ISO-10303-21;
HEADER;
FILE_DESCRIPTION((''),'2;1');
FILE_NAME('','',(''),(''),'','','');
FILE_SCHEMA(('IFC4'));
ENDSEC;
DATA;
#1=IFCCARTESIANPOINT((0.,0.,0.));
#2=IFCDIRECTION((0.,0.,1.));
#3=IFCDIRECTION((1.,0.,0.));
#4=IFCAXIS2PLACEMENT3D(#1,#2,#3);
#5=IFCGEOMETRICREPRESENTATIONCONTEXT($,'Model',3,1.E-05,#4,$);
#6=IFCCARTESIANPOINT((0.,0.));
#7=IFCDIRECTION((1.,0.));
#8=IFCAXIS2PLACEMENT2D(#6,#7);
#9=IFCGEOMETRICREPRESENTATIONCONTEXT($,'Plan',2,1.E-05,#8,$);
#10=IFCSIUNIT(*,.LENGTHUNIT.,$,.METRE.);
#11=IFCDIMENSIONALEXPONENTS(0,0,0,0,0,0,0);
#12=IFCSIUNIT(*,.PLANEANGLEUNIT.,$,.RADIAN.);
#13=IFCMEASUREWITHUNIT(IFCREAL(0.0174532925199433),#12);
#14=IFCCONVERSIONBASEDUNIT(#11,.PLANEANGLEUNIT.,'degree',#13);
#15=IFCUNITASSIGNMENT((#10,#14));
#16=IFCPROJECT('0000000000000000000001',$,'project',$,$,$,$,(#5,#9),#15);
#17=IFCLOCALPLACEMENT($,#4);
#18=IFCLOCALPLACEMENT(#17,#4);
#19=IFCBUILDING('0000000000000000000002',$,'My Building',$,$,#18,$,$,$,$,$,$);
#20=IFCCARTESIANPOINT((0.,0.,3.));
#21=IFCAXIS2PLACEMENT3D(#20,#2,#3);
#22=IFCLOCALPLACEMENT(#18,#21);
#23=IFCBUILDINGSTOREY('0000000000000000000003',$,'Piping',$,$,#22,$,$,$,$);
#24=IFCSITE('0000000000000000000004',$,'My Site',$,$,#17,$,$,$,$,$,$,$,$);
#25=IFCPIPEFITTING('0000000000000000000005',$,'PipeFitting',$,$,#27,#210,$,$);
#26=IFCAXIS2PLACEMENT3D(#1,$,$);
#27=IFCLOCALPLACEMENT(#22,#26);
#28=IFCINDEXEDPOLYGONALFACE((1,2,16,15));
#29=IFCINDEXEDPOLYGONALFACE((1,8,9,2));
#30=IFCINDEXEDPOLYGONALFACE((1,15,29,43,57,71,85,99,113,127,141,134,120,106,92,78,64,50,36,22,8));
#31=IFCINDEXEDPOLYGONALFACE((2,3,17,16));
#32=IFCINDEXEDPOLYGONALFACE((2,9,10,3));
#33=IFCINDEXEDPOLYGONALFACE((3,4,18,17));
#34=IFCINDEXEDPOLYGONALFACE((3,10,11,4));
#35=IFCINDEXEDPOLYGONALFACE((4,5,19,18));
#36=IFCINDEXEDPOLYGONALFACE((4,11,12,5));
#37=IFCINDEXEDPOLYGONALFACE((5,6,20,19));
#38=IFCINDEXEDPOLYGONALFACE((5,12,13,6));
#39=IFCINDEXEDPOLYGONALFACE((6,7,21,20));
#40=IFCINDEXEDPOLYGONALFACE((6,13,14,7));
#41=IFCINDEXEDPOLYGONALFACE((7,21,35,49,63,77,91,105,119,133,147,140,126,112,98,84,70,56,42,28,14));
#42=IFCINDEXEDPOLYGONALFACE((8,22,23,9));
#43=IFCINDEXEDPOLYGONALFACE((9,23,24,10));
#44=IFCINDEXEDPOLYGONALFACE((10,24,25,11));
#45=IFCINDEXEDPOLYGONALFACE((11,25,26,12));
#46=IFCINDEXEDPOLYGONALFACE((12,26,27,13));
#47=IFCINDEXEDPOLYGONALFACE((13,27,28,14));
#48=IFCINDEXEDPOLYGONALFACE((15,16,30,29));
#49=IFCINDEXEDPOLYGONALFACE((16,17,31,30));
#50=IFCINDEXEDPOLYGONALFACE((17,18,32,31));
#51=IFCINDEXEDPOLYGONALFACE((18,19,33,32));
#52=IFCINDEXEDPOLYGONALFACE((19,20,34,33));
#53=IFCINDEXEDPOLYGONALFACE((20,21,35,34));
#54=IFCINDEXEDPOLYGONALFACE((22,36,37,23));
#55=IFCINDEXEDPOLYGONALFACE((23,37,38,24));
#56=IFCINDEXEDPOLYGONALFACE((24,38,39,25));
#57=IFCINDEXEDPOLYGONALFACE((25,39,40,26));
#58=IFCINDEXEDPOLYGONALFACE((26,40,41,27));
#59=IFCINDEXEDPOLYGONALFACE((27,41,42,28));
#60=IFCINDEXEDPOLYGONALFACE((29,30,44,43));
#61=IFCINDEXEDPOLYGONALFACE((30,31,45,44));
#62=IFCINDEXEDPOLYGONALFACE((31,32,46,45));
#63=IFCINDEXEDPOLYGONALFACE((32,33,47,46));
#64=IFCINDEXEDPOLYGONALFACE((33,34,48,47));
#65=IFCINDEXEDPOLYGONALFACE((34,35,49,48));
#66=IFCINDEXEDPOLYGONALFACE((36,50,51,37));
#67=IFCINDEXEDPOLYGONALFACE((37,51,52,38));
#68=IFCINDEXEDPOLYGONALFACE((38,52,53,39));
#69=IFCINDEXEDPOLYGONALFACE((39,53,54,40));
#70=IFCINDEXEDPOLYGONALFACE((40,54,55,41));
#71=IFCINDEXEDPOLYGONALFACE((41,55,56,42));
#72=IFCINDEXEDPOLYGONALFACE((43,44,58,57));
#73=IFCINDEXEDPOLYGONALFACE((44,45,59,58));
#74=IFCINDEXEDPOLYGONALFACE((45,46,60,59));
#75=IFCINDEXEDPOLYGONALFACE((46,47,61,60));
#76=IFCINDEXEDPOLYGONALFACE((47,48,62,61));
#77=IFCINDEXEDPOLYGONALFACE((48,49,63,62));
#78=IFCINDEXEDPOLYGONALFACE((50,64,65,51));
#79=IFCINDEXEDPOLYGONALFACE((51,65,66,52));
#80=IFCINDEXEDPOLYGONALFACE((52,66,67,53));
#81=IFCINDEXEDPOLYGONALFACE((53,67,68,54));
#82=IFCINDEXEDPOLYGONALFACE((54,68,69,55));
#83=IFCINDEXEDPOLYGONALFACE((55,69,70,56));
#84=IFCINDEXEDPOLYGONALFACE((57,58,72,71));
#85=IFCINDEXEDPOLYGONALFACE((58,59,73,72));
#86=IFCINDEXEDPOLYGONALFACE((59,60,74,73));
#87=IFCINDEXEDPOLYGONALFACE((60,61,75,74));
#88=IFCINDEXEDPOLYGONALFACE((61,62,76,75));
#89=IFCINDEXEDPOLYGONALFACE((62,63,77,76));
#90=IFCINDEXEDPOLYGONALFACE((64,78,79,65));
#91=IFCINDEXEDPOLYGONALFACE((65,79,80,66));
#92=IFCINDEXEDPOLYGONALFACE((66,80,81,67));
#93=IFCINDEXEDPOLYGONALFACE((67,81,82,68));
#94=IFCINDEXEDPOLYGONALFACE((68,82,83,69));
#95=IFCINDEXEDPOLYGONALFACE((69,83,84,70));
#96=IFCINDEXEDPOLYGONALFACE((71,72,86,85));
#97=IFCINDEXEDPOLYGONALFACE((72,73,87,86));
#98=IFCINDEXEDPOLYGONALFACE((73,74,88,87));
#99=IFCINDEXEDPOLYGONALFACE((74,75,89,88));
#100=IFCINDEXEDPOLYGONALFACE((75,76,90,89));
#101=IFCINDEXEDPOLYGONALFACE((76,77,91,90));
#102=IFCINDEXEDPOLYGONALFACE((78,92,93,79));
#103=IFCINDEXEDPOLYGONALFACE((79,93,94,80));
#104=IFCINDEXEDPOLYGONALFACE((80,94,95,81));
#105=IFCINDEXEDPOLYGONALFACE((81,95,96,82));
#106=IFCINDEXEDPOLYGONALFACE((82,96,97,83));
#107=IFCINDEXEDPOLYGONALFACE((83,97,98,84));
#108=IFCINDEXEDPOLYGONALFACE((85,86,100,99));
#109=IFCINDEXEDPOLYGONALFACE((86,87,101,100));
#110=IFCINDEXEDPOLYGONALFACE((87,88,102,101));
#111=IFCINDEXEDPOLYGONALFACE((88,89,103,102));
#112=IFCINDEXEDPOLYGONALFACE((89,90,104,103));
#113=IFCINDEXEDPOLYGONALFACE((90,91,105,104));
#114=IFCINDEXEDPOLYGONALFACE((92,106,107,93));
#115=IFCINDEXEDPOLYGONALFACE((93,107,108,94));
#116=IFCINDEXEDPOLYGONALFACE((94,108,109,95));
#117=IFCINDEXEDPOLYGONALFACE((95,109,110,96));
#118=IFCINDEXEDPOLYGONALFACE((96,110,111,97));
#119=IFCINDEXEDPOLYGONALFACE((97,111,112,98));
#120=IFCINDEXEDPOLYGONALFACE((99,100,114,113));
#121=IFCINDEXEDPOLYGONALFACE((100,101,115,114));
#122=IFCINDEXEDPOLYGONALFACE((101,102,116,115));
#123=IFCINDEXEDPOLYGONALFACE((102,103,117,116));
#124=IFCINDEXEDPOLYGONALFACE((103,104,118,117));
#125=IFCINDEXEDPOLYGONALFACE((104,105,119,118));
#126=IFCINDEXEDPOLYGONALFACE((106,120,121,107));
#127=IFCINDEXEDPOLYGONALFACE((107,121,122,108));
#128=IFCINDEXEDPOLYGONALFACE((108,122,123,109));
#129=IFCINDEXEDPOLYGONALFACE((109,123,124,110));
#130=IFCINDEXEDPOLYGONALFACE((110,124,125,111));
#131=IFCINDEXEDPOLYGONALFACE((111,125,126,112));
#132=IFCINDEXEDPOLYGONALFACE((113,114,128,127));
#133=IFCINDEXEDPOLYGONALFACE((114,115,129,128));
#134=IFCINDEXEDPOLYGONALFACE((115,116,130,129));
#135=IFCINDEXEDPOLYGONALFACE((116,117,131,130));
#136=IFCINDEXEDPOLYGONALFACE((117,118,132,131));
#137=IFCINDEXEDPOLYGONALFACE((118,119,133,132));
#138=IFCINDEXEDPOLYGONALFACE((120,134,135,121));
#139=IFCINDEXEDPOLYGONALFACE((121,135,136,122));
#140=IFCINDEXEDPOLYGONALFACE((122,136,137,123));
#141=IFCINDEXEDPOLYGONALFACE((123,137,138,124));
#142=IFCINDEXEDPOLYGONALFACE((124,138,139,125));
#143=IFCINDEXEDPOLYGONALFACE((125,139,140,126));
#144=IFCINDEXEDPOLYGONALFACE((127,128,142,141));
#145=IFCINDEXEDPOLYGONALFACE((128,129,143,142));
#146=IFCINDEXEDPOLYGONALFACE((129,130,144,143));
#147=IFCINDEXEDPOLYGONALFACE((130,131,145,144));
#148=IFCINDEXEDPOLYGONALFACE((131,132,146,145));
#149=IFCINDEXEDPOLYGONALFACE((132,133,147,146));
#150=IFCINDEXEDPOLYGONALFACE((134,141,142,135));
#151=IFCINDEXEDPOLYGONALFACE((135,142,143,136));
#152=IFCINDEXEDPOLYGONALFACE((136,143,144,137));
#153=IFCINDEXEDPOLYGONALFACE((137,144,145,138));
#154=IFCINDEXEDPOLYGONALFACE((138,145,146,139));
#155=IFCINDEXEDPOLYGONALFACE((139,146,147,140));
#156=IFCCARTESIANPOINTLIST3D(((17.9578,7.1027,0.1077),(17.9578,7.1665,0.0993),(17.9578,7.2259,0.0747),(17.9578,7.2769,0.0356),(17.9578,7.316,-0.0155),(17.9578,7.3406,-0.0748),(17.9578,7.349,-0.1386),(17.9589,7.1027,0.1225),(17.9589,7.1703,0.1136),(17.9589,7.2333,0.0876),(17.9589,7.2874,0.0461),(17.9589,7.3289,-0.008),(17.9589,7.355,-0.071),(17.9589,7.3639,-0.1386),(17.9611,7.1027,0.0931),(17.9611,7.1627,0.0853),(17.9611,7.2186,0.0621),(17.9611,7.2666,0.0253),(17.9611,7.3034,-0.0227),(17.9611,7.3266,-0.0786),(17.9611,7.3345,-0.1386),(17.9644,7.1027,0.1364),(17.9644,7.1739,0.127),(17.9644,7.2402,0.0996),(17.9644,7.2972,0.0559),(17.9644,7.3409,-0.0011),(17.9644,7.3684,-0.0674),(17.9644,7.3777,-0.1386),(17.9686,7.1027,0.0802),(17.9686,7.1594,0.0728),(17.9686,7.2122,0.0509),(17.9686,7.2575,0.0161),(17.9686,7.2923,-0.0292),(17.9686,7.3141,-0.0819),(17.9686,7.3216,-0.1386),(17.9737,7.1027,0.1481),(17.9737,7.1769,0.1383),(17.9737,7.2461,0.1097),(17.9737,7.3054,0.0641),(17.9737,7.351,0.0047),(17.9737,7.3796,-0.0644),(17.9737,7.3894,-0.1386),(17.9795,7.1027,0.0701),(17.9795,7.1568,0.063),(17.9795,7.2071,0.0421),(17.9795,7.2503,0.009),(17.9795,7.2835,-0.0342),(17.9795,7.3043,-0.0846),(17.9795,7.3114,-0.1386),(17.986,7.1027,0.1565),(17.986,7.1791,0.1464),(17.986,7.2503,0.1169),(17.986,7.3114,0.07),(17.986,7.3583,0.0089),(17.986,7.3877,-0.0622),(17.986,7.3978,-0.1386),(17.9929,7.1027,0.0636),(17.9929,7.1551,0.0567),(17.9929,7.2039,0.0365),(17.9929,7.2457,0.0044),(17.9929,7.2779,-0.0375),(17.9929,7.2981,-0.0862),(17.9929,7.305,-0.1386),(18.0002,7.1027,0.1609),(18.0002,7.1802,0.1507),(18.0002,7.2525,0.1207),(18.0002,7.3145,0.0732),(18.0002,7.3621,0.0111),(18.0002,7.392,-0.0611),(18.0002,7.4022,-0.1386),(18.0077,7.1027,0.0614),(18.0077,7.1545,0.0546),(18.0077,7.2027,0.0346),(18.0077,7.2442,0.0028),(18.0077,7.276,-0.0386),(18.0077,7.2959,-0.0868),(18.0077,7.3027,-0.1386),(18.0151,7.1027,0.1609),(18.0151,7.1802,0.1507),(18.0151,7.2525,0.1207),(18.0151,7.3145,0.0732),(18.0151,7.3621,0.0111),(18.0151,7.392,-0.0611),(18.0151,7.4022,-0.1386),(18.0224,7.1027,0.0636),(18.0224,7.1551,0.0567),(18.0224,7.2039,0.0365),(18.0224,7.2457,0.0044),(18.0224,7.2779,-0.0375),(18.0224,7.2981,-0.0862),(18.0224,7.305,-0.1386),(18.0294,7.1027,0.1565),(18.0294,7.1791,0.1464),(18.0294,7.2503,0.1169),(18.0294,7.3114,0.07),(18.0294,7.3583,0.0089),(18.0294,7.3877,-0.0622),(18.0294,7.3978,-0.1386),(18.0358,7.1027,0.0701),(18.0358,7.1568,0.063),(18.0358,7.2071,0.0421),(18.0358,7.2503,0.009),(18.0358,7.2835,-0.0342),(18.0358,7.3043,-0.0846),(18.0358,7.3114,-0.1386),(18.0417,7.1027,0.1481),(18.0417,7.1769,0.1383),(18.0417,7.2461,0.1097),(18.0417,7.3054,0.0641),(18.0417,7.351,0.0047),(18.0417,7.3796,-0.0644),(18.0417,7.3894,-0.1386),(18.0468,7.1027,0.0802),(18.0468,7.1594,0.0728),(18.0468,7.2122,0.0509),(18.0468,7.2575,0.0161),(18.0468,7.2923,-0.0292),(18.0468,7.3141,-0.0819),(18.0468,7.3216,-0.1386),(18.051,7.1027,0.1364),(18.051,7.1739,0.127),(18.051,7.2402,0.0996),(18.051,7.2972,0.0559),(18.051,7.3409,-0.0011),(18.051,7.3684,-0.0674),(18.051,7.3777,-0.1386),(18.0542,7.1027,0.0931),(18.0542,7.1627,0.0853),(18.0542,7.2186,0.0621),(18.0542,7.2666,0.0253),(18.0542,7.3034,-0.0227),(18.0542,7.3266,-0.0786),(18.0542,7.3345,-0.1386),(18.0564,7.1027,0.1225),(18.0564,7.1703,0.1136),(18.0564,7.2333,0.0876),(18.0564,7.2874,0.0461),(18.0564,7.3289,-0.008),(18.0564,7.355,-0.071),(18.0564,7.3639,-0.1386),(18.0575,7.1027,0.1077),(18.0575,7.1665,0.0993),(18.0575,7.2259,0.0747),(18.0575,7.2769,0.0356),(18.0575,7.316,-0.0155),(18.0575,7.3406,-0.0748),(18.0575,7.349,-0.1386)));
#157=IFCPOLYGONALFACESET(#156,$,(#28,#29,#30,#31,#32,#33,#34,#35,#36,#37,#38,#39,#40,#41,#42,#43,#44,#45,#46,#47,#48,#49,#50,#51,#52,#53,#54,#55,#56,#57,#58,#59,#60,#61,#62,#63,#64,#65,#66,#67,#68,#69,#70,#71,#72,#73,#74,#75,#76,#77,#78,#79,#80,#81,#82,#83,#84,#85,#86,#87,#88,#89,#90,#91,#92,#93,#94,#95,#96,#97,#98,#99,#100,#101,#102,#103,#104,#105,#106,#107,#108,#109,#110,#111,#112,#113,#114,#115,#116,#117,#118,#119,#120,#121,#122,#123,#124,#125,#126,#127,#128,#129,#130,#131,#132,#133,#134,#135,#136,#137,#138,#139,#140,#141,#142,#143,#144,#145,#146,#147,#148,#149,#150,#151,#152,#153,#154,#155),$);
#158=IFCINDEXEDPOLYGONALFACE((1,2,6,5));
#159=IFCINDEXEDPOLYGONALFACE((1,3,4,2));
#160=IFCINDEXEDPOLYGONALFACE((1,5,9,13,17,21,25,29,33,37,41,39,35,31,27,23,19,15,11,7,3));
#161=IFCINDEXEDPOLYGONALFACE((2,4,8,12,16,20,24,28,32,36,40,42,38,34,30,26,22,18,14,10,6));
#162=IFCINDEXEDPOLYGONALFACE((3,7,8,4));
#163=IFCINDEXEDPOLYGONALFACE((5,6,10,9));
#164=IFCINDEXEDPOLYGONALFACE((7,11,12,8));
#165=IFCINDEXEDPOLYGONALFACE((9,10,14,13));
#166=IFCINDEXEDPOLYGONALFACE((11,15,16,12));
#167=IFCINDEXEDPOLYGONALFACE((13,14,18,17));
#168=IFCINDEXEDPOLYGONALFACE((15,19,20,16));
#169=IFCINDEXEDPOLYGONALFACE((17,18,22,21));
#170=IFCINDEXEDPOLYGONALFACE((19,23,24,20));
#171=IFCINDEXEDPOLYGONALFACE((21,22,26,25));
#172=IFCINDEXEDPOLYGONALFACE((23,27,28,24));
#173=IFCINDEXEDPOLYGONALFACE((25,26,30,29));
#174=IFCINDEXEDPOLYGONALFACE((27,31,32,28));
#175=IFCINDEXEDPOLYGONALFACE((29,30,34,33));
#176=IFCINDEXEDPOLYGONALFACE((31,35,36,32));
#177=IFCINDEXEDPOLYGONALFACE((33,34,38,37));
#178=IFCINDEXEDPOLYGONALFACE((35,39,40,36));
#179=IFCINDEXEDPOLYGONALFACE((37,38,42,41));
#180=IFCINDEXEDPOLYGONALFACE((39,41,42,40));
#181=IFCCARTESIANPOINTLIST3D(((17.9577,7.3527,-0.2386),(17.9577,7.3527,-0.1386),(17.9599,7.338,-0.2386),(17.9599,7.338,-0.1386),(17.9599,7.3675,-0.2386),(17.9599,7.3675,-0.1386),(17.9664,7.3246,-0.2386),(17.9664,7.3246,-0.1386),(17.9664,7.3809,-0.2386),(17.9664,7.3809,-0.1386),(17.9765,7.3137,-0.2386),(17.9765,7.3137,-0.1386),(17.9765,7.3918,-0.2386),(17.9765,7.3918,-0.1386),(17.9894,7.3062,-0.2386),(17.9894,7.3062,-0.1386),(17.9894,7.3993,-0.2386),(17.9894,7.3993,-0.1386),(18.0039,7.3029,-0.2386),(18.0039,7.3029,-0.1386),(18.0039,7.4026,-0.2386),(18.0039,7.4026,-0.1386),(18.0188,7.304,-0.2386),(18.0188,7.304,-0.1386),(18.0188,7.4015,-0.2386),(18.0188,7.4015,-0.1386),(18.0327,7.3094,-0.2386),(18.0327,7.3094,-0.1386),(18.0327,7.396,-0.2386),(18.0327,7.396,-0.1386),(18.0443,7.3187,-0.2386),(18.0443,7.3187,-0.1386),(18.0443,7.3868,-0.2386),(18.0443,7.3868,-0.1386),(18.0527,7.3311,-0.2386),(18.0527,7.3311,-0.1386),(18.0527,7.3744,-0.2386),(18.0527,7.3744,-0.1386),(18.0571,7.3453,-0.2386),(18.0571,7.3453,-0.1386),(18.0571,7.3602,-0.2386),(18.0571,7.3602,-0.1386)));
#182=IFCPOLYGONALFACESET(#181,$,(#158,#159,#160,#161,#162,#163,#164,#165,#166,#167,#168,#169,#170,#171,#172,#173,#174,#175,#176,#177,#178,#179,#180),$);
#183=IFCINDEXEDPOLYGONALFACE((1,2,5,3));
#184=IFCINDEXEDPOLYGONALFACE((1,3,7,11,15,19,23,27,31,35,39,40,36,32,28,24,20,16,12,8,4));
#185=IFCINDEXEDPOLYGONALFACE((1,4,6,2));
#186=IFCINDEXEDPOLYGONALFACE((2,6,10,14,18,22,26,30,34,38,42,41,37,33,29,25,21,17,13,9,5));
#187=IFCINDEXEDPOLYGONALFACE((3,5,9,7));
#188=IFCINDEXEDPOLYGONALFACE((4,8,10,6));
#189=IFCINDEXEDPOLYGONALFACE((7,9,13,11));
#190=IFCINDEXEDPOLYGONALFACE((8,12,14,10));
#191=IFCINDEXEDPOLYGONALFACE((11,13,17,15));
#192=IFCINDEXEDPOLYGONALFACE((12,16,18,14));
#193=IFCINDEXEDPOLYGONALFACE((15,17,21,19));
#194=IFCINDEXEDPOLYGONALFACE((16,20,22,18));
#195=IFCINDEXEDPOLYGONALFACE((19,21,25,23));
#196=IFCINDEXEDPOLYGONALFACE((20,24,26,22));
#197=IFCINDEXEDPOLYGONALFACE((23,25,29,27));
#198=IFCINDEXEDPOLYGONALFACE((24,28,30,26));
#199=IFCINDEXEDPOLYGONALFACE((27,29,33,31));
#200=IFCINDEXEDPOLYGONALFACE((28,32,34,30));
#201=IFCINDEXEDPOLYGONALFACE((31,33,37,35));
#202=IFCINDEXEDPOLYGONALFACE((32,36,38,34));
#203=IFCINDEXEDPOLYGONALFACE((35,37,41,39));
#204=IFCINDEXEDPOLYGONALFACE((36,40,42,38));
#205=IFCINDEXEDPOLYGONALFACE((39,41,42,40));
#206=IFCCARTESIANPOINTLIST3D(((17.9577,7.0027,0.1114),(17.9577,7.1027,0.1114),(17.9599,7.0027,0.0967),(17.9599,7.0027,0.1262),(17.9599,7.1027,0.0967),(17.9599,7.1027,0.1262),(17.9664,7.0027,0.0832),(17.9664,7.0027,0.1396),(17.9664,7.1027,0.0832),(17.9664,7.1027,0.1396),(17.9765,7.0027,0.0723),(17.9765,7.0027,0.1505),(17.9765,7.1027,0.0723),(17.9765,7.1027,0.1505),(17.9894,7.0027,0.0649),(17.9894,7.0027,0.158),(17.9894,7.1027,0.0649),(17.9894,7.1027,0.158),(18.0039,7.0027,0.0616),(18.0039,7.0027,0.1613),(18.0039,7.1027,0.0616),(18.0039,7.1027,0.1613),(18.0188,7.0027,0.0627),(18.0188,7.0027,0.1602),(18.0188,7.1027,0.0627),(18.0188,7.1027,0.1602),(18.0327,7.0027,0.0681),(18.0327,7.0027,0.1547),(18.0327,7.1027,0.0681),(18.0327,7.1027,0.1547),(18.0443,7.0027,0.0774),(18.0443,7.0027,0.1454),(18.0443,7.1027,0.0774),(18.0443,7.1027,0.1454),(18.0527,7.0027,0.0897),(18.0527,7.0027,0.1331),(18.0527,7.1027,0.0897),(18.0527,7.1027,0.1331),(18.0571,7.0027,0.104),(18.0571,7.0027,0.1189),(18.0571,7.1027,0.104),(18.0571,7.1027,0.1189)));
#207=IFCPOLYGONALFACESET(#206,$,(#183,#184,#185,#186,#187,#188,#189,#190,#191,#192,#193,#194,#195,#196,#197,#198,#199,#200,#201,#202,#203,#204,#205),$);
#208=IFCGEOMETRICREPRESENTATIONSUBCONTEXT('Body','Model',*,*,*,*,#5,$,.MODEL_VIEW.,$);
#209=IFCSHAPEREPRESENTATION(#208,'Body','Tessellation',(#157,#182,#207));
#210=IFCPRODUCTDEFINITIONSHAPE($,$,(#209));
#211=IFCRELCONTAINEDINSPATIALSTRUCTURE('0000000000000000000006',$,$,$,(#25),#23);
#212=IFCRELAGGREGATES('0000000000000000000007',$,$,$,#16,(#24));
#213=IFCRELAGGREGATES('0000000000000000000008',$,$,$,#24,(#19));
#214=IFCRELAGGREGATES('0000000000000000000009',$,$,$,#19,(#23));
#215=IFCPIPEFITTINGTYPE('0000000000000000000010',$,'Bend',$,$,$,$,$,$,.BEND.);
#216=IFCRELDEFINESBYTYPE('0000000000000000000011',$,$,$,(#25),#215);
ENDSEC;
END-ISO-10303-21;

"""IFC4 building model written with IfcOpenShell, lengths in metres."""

from ifc_helpers import new_model, entity, si_unit, converted_unit, frame, origin_with_axes, origin_2d_with_axis, place, context, subcontext, project, spatial, circle, extrude, source, transform, mapped, type_object, type_shapes, element, save


model = new_model("IFC4")

# Units and contexts
model_context = context("Model", 3, precision=1e-05, world=origin_with_axes())
plan_context = context("Plan", 2, precision=1e-05, world=origin_2d_with_axis())
body_context = subcontext(model_context, "Body", "Model", "MODEL_VIEW")
ifc_project = project(units=[si_unit("LENGTHUNIT", "METRE"), converted_unit("PLANEANGLEUNIT", "degree", entity("IfcReal", 0.0174532925199433), si_unit("PLANEANGLEUNIT", "RADIAN"), dimensions=[0, 0, 0, 0, 0, 0, 0])], contexts=[model_context, plan_context])

# Site, building, storey
site_placement = place(None, origin_with_axes())
site = spatial("IfcSite", under=ifc_project, at=site_placement, Name="My Site")
building_placement = place(site_placement, origin_with_axes())
building = spatial("IfcBuilding", under=site, at=building_placement, Name="My Building")
storey_placement = place(building_placement, frame((0.0, 0.0, 3.0), z_axis=(0.0, 0.0, 1.0), x_axis=(1.0, 0.0, 0.0)))
storey = spatial("IfcBuildingStorey", under=building, at=storey_placement, Name="Piping")

# Pipe fitting
pipe_fitting_type_1 = type_object("IfcPipeFittingType", Name="Bend", PredefinedType="BEND")
shared_shape = source(origin_with_axes(), body_context, "Body", "SolidModel", [
    entity("IfcSweptDiskSolid", entity("IfcIndexedPolyCurve", entity("IfcCartesianPointList3D", [[0.0, 0.0, -0.1], [0.0, -0.0732, -0.2768], [0.0, -0.25, -0.35]]), [entity("IfcArcIndex", [1, 2, 3])]), 0.05),
    extrude(circle(Radius=0.05), origin_with_axes(), (0.0, 0.0, -1.0), 0.1),
    extrude(circle(Radius=0.05), frame((0.0, -0.25, -0.35), z_axis=(0.0, -1.0, 0.0), x_axis=(1.0, 0.0, 0.0)), (0.0, 0.0, 1.0), 0.1),
])
type_shapes(pipe_fitting_type_1, [shared_shape])
for number, where, z_axis, x_axis, name in (
    (1, (18.0077, 7.3527, -0.2386), (0.0, 0.0, -1.0), (-1.0, 0.0, 0.0), "PipeFitting"),
):
    element("IfcPipeFitting", number, at=place(storey_placement, frame(where, z_axis=z_axis, x_axis=x_axis)), inside=storey, type_object=pipe_fitting_type_1, Name=name, context=body_context, shape_type="MappedRepresentation", body=[
        mapped(shared_shape, transform((0.0, 0.0, 0.0), x_axis=(1.0, 0.0, 0.0), y_axis=(0.0, 1.0, 0.0), z_axis=(0.0, 0.0, 1.0), scale=1.0)),
    ])

save(model, "model.ifc")
